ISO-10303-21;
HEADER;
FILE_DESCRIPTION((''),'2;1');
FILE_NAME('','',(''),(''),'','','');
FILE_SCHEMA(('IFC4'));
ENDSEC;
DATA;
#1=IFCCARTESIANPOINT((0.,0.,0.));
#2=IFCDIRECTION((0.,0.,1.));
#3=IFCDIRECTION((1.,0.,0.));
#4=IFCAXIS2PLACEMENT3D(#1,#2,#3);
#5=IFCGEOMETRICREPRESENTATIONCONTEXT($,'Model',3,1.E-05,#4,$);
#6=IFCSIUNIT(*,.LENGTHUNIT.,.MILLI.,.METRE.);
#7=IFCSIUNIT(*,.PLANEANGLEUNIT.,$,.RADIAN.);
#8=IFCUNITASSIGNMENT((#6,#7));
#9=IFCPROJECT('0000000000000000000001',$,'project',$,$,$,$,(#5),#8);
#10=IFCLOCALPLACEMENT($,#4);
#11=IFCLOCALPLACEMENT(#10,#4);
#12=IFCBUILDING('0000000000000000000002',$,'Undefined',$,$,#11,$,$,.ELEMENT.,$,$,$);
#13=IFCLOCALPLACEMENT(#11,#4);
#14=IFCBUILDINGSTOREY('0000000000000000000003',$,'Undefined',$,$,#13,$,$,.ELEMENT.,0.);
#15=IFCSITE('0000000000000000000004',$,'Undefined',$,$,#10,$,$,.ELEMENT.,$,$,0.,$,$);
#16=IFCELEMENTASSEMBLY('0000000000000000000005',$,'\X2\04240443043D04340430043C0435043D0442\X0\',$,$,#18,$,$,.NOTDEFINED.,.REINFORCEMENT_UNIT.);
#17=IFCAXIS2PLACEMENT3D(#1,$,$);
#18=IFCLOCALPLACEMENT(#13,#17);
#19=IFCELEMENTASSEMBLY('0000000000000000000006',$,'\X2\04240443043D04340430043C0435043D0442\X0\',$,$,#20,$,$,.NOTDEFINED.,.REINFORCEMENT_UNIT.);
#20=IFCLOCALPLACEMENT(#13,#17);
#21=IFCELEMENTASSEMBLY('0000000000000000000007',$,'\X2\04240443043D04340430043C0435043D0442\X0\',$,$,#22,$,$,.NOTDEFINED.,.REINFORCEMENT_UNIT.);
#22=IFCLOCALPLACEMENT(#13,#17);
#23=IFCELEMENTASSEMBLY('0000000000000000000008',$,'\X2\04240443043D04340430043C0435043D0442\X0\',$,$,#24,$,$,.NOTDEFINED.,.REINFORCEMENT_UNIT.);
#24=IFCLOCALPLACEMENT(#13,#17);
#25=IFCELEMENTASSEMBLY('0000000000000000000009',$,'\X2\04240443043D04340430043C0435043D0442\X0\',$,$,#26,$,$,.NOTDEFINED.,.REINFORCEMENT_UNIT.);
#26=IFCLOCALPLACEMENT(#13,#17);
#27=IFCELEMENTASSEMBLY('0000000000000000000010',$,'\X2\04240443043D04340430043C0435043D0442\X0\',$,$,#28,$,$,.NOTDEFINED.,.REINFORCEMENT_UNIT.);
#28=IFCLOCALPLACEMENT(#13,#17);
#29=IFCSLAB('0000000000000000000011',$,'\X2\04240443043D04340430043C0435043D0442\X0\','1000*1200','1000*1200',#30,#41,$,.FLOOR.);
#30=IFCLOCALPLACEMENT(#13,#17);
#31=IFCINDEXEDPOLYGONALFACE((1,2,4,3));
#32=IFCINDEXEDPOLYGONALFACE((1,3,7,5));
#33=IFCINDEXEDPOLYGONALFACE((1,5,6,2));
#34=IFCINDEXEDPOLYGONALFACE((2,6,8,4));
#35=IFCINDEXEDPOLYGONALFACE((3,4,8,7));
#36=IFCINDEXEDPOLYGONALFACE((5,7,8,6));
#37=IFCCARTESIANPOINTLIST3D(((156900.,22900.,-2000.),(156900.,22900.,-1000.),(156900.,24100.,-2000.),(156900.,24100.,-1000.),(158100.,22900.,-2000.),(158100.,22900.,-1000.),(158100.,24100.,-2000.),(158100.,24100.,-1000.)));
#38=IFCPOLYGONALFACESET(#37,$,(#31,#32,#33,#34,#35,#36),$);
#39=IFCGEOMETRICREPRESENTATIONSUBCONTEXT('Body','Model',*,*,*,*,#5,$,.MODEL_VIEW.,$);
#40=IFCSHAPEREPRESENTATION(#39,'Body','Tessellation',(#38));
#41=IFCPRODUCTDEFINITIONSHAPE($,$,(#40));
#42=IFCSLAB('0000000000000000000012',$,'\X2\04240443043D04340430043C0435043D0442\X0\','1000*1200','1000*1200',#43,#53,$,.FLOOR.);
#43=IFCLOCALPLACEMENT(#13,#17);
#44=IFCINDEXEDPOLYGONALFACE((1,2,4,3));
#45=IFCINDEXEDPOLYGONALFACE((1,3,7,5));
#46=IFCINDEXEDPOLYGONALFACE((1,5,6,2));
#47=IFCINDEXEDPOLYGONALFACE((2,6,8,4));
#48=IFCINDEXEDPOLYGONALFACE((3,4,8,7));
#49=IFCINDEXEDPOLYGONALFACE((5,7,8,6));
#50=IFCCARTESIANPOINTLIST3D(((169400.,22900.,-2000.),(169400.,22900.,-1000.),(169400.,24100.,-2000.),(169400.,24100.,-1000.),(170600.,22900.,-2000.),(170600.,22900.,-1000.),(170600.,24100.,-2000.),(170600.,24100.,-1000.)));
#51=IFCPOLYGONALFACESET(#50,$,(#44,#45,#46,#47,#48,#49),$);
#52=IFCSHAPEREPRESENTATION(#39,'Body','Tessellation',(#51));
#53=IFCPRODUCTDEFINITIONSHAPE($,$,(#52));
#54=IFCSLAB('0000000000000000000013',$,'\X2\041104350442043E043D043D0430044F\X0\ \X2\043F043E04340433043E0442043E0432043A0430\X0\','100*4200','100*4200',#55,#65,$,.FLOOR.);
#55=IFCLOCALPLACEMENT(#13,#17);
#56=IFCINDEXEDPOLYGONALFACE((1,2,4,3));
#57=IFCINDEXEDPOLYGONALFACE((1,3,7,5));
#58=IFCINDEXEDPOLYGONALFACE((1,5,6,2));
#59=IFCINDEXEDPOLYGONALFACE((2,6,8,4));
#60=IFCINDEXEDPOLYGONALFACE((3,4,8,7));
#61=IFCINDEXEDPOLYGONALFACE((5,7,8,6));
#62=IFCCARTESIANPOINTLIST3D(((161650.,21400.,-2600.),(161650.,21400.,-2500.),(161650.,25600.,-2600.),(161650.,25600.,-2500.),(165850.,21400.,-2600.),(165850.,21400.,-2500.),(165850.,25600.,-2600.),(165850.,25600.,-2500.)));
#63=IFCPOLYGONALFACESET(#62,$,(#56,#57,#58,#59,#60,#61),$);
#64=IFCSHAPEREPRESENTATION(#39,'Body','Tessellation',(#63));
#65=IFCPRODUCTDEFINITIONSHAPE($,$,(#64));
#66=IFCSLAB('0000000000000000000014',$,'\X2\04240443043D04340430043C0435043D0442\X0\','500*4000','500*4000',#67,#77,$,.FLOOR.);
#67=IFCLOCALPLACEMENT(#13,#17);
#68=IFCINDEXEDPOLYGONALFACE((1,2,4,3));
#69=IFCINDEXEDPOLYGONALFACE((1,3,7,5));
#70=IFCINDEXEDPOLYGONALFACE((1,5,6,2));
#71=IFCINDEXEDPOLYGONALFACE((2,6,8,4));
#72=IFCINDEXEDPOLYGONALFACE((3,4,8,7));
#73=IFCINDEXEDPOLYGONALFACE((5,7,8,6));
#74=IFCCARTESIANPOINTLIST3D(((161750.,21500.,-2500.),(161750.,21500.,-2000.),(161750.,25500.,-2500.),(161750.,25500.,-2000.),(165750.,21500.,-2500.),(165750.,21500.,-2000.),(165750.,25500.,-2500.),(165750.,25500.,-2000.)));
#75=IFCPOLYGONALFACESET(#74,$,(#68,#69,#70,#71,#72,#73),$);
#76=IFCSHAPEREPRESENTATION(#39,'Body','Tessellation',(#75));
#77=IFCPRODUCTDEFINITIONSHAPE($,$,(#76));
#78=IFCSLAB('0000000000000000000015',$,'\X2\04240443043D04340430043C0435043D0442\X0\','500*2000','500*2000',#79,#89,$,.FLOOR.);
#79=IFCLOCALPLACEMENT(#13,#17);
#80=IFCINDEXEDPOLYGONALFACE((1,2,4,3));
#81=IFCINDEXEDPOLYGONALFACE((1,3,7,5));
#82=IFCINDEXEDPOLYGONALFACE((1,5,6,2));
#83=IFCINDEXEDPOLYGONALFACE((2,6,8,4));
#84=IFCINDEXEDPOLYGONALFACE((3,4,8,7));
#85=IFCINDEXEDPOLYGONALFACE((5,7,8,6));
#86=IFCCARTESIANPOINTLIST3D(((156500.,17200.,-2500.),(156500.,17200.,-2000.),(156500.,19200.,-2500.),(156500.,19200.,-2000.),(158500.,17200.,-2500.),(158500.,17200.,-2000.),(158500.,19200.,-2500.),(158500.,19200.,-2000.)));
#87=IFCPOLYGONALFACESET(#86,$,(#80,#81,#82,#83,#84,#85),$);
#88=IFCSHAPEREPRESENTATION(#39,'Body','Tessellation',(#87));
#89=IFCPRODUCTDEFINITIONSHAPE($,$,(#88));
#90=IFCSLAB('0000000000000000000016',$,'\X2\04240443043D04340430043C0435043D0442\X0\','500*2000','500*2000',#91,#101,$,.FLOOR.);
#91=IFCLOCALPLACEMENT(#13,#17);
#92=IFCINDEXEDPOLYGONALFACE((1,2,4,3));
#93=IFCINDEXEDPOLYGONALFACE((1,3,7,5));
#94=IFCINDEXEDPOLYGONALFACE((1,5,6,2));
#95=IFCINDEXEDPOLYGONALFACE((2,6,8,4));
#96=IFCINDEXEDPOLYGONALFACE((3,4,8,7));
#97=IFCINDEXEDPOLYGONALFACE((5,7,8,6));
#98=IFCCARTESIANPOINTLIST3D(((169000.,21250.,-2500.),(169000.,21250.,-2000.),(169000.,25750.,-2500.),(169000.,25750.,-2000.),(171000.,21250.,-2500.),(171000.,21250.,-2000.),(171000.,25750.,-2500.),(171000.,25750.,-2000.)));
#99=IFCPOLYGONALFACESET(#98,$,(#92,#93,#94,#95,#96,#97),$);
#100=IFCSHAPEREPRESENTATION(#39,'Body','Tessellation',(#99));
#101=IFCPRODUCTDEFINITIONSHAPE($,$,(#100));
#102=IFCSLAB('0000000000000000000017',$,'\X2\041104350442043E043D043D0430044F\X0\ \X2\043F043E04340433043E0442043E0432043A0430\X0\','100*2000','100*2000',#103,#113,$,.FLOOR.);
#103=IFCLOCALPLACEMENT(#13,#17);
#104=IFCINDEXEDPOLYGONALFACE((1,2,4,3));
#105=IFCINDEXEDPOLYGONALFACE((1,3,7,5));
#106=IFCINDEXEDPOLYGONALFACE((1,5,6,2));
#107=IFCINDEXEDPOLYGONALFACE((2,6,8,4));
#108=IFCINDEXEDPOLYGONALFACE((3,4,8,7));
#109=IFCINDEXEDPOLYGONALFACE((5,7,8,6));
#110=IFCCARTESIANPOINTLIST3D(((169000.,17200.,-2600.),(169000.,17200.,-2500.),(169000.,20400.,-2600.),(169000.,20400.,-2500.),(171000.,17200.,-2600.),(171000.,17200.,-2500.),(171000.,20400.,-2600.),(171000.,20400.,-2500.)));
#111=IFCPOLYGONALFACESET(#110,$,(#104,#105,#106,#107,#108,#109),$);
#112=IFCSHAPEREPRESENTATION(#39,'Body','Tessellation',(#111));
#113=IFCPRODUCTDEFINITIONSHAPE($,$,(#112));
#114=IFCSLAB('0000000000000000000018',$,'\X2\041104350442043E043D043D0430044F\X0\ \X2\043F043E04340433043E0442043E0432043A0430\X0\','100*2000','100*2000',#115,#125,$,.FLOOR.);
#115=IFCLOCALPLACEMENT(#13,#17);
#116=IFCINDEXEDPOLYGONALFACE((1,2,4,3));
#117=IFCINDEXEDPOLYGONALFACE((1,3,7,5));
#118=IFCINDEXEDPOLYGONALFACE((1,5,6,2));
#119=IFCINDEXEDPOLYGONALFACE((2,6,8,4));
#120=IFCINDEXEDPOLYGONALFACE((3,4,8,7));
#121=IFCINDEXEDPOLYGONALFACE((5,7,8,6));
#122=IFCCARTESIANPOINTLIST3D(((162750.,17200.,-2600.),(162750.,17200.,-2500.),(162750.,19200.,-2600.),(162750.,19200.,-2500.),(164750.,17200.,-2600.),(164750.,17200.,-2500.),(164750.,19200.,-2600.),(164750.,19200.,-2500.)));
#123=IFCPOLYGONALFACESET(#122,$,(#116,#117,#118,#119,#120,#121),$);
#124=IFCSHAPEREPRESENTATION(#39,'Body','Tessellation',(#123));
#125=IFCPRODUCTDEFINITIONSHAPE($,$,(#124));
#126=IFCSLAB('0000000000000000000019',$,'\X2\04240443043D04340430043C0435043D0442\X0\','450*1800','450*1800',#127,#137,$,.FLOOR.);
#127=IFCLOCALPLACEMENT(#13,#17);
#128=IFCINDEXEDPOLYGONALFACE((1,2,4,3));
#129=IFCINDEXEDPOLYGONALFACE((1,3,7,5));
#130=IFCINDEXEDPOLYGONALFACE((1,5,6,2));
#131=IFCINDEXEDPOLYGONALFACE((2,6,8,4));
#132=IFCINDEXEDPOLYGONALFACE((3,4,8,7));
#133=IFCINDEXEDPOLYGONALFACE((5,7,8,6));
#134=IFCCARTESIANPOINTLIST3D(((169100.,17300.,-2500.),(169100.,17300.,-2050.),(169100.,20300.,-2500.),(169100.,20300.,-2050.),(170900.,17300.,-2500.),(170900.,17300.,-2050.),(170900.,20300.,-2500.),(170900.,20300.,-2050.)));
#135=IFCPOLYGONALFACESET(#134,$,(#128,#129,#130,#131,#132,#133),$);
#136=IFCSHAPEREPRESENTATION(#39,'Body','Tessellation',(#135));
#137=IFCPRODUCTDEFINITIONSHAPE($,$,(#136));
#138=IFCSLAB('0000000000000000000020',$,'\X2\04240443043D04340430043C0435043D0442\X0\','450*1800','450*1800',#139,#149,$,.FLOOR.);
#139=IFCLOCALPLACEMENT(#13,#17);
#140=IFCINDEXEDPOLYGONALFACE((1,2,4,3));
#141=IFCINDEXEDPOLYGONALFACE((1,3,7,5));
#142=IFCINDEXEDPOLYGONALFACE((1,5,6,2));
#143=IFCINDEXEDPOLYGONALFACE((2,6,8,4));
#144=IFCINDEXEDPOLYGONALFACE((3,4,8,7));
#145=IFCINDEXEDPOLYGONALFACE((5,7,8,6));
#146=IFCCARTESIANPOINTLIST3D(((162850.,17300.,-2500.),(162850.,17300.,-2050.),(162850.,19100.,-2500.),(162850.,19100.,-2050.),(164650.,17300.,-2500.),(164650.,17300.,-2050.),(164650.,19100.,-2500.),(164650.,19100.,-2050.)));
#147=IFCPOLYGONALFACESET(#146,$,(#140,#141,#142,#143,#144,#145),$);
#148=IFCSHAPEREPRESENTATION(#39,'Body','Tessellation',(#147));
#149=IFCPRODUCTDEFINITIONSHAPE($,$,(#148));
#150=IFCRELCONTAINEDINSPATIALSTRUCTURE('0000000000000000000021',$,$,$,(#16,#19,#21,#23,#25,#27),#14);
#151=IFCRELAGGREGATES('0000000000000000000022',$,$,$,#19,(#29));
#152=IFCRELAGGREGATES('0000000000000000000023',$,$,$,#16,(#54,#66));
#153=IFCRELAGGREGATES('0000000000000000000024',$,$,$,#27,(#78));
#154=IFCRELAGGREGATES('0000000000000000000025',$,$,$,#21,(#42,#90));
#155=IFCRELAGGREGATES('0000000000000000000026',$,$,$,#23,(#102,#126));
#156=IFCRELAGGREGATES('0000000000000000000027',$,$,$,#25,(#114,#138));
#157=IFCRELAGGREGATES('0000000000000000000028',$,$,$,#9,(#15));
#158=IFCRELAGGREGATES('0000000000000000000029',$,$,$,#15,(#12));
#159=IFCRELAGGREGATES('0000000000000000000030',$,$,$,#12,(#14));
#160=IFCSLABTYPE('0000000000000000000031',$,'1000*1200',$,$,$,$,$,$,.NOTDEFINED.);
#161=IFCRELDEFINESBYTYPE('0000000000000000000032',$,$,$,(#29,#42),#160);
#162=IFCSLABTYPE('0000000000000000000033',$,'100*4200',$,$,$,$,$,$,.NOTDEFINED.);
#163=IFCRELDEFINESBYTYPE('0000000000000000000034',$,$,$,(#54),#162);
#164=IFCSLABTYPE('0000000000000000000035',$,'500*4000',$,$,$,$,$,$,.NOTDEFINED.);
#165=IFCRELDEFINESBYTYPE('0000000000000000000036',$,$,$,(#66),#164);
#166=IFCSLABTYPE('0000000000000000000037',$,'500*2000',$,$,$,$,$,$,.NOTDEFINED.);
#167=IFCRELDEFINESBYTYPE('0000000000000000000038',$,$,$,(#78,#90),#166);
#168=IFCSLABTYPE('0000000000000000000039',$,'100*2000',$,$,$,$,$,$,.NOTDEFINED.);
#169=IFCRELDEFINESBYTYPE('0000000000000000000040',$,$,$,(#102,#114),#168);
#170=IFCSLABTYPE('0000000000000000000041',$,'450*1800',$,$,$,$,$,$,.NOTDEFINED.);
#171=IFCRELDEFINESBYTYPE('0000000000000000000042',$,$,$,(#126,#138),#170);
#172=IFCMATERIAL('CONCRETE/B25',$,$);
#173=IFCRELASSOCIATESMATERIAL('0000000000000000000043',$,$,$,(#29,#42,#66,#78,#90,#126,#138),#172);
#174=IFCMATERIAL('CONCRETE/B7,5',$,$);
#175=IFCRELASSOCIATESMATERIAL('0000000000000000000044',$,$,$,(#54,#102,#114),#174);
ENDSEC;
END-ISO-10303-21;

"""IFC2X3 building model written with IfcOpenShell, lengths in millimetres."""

from ifc_helpers import new_model, si_unit, frame, origin_with_axes, place, context, subcontext, project, spatial, polyline, outline, extrude, material, type_object, element, aggregate, save


model = new_model("IFC2X3")

# Units and contexts
model_context = context("Model", 3, precision=1e-05, world=origin_with_axes())
body_context = subcontext(model_context, "Body", "Model", "MODEL_VIEW")
ifc_project = project(units=[si_unit("LENGTHUNIT", "METRE", prefix="MILLI"), si_unit("PLANEANGLEUNIT", "RADIAN")], contexts=[model_context])

# Site, building, storey
site_placement = place(None, origin_with_axes())
site = spatial("IfcSite", under=ifc_project, at=site_placement, Name="Undefined", CompositionType="ELEMENT", RefElevation=0.0)
building_placement = place(site_placement, origin_with_axes())
building = spatial("IfcBuilding", under=site, at=building_placement, Name="Undefined", CompositionType="ELEMENT")
storey_placement = place(building_placement, origin_with_axes())
storey = spatial("IfcBuildingStorey", under=building, at=storey_placement, Name="Undefined", CompositionType="ELEMENT", Elevation=0.0)

# Element assemblies
assembly_1_placement = place(storey_placement, origin_with_axes())
assembly_1 = element("IfcElementAssembly", 1, at=assembly_1_placement, inside=storey, Name="Фундамент", AssemblyPlace="NOTDEFINED", PredefinedType="REINFORCEMENT_UNIT")
ifc_material_1 = material(Name="CONCRETE/B25")
assembly_2_placement = place(storey_placement, origin_with_axes())
assembly_2 = element("IfcElementAssembly", 2, at=assembly_2_placement, inside=storey, Name="Фундамент", AssemblyPlace="NOTDEFINED", PredefinedType="REINFORCEMENT_UNIT")
assembly_3_placement = place(storey_placement, origin_with_axes())
assembly_3 = element("IfcElementAssembly", 3, at=assembly_3_placement, inside=storey, Name="Фундамент", AssemblyPlace="NOTDEFINED", PredefinedType="REINFORCEMENT_UNIT")

# Shared definitions
ifc_material_2 = material(Name="CONCRETE/B7,5")

# Element assembly
assembly_4_placement = place(storey_placement, origin_with_axes())
assembly_4 = element("IfcElementAssembly", 4, at=assembly_4_placement, inside=storey, Name="Фундамент", AssemblyPlace="NOTDEFINED", PredefinedType="REINFORCEMENT_UNIT")

# Element assemblies
assembly_5_placement = place(storey_placement, origin_with_axes())
assembly_5 = element("IfcElementAssembly", 5, at=assembly_5_placement, inside=storey, Name="Фундамент", AssemblyPlace="NOTDEFINED", PredefinedType="REINFORCEMENT_UNIT")
assembly_6_placement = place(storey_placement, origin_with_axes())
assembly_6 = element("IfcElementAssembly", 6, at=assembly_6_placement, inside=storey, Name="Фундамент", AssemblyPlace="NOTDEFINED", PredefinedType="REINFORCEMENT_UNIT")

# Slabs
slab_type_1 = type_object("IfcSlabType", Name="1000*1200", PredefinedType="NOTDEFINED")
slab_1_placement = place(assembly_2_placement, frame((156900.0, 24100.0, -1500.0), z_axis=(0.0, 0.0, 1.0), x_axis=(0.0, -1.0, 0.0)))
slab_1 = element("IfcSlab", 7, at=slab_1_placement, type_object=slab_type_1, material=ifc_material_1, Name="Фундамент", Description="1000*1200", ObjectType="1000*1200", PredefinedType="FLOOR", context=body_context, shape_type="SweptSolid", body=[
    extrude(outline(polyline([(0.0, 0.0), (1200.0, 0.0), (1200.0, 1200.0), (0.0, 1200.0), (0.0, 0.0)])), frame((0.0, 0.0, -500.0), z_axis=(0.0, 0.0, 1.0), x_axis=(1.0, 0.0, 0.0)), (0.0, 0.0, 1.0), 1000.0),
])
aggregate(assembly_2, [slab_1])
slab_2_placement = place(assembly_3_placement, frame((169400.0, 24100.0, -1500.0), z_axis=(0.0, 0.0, 1.0), x_axis=(0.0, -1.0, 0.0)))
slab_2 = element("IfcSlab", 8, at=slab_2_placement, type_object=slab_type_1, material=ifc_material_1, Name="Фундамент", Description="1000*1200", ObjectType="1000*1200", PredefinedType="FLOOR", context=body_context, shape_type="SweptSolid", body=[
    extrude(outline(polyline([(0.0, 0.0), (1200.0, 0.0), (1200.0, 1200.0), (0.0, 1200.0), (0.0, 0.0)])), frame((0.0, 0.0, -500.0), z_axis=(0.0, 0.0, 1.0), x_axis=(1.0, 0.0, 0.0)), (0.0, 0.0, 1.0), 1000.0),
])
slab_type_2 = type_object("IfcSlabType", Name="100*4200", PredefinedType="NOTDEFINED")
slab_3_placement = place(assembly_1_placement, frame((161650.0, 25600.0, -2550.0), z_axis=(0.0, 0.0, 1.0), x_axis=(0.0, -1.0, 0.0)))
slab_3 = element("IfcSlab", 9, at=slab_3_placement, type_object=slab_type_2, material=ifc_material_2, Name="Бетонная подготовка", Description="100*4200", ObjectType="100*4200", PredefinedType="FLOOR", context=body_context, shape_type="SweptSolid", body=[
    extrude(outline(polyline([(0.0, 0.0), (4200.0, 0.0), (4200.0, 4200.0), (0.0, 4200.0), (0.0, 0.0)])), frame((0.0, 0.0, -50.0), z_axis=(0.0, 0.0, 1.0), x_axis=(1.0, 0.0, 0.0)), (0.0, 0.0, 1.0), 100.0),
])
slab_type_3 = type_object("IfcSlabType", Name="500*4000", PredefinedType="NOTDEFINED")
slab_4_placement = place(assembly_1_placement, frame((161750.0, 25500.0, -2250.0), z_axis=(0.0, 0.0, 1.0), x_axis=(0.0, -1.0, 0.0)))
slab_4 = element("IfcSlab", 10, at=slab_4_placement, type_object=slab_type_3, material=ifc_material_1, Name="Фундамент", Description="500*4000", ObjectType="500*4000", PredefinedType="FLOOR", context=body_context, shape_type="SweptSolid", body=[
    extrude(outline(polyline([(0.0, 0.0), (4000.0, 0.0), (4000.0, 4000.0), (0.0, 4000.0), (0.0, 0.0)])), frame((0.0, 0.0, -250.0), z_axis=(0.0, 0.0, 1.0), x_axis=(1.0, 0.0, 0.0)), (0.0, 0.0, 1.0), 500.0),
])
aggregate(assembly_1, [slab_3, slab_4])
slab_type_4 = type_object("IfcSlabType", Name="500*2000", PredefinedType="NOTDEFINED")
slab_5_placement = place(assembly_6_placement, frame((156500.0, 19200.0, -2250.0), z_axis=(0.0, 0.0, 1.0), x_axis=(0.0, -1.0, 0.0)))
slab_5 = element("IfcSlab", 11, at=slab_5_placement, type_object=slab_type_4, material=ifc_material_1, Name="Фундамент", Description="500*2000", ObjectType="500*2000", PredefinedType="FLOOR", context=body_context, shape_type="SweptSolid", body=[
    extrude(outline(polyline([(0.0, 0.0), (2000.0, 0.0), (2000.0, 2000.0), (0.0, 2000.0), (0.0, 0.0)])), frame((0.0, 0.0, -250.0), z_axis=(0.0, 0.0, 1.0), x_axis=(1.0, 0.0, 0.0)), (0.0, 0.0, 1.0), 500.0),
])
aggregate(assembly_6, [slab_5])
slab_6_placement = place(assembly_3_placement, frame((169000.0, 25750.0, -2250.0), z_axis=(0.0, 0.0, 1.0), x_axis=(0.0, -1.0, 0.0)))
slab_6 = element("IfcSlab", 12, at=slab_6_placement, type_object=slab_type_4, material=ifc_material_1, Name="Фундамент", Description="500*2000", ObjectType="500*2000", PredefinedType="FLOOR", context=body_context, shape_type="SweptSolid", body=[
    extrude(outline(polyline([(0.0, 0.0), (4500.0, 0.0), (4500.0, 2000.0), (0.0, 2000.0), (0.0, 0.0)])), frame((0.0, 0.0, -250.0), z_axis=(0.0, 0.0, 1.0), x_axis=(1.0, 0.0, 0.0)), (0.0, 0.0, 1.0), 500.0),
])
aggregate(assembly_3, [slab_2, slab_6])
slab_type_5 = type_object("IfcSlabType", Name="100*2000", PredefinedType="NOTDEFINED")
slab_7_placement = place(assembly_4_placement, frame((169000.0, 20400.0, -2550.0), z_axis=(0.0, 0.0, 1.0), x_axis=(0.0, -1.0, 0.0)))
slab_7 = element("IfcSlab", 13, at=slab_7_placement, type_object=slab_type_5, material=ifc_material_2, Name="Бетонная подготовка", Description="100*2000", ObjectType="100*2000", PredefinedType="FLOOR", context=body_context, shape_type="SweptSolid", body=[
    extrude(outline(polyline([(0.0, 0.0), (3200.0, 0.0), (3200.0, 2000.0), (0.0, 2000.0), (0.0, 0.0)])), frame((0.0, 0.0, -50.0), z_axis=(0.0, 0.0, 1.0), x_axis=(1.0, 0.0, 0.0)), (0.0, 0.0, 1.0), 100.0),
])
slab_8_placement = place(assembly_5_placement, frame((162750.0, 19200.0, -2550.0), z_axis=(0.0, 0.0, 1.0), x_axis=(0.0, -1.0, 0.0)))
slab_8 = element("IfcSlab", 14, at=slab_8_placement, type_object=slab_type_5, material=ifc_material_2, Name="Бетонная подготовка", Description="100*2000", ObjectType="100*2000", PredefinedType="FLOOR", context=body_context, shape_type="SweptSolid", body=[
    extrude(outline(polyline([(0.0, 0.0), (2000.0, 0.0), (2000.0, 2000.0), (0.0, 2000.0), (0.0, 0.0)])), frame((0.0, 0.0, -50.0), z_axis=(0.0, 0.0, 1.0), x_axis=(1.0, 0.0, 0.0)), (0.0, 0.0, 1.0), 100.0),
])
slab_type_6 = type_object("IfcSlabType", Name="450*1800", PredefinedType="NOTDEFINED")
slab_9_placement = place(assembly_4_placement, frame((169100.0, 20300.0, -2275.0), z_axis=(0.0, 0.0, 1.0), x_axis=(0.0, -1.0, 0.0)))
slab_9 = element("IfcSlab", 15, at=slab_9_placement, type_object=slab_type_6, material=ifc_material_1, Name="Фундамент", Description="450*1800", ObjectType="450*1800", PredefinedType="FLOOR", context=body_context, shape_type="SweptSolid", body=[
    extrude(outline(polyline([(0.0, 0.0), (3000.0, 0.0), (3000.0, 1800.0), (0.0, 1800.0), (0.0, 0.0)])), frame((0.0, 0.0, -225.0), z_axis=(0.0, 0.0, 1.0), x_axis=(1.0, 0.0, 0.0)), (0.0, 0.0, 1.0), 450.0),
])
aggregate(assembly_4, [slab_7, slab_9])
slab_10_placement = place(assembly_5_placement, frame((162850.0, 19100.0, -2275.0), z_axis=(0.0, 0.0, 1.0), x_axis=(0.0, -1.0, 0.0)))
slab_10 = element("IfcSlab", 16, at=slab_10_placement, type_object=slab_type_6, material=ifc_material_1, Name="Фундамент", Description="450*1800", ObjectType="450*1800", PredefinedType="FLOOR", context=body_context, shape_type="SweptSolid", body=[
    extrude(outline(polyline([(0.0, 0.0), (1800.0, 0.0), (1800.0, 1800.0), (0.0, 1800.0), (0.0, 0.0)])), frame((0.0, 0.0, -225.0), z_axis=(0.0, 0.0, 1.0), x_axis=(1.0, 0.0, 0.0)), (0.0, 0.0, 1.0), 450.0),
])
aggregate(assembly_5, [slab_8, slab_10])

save(model, "model.ifc")
